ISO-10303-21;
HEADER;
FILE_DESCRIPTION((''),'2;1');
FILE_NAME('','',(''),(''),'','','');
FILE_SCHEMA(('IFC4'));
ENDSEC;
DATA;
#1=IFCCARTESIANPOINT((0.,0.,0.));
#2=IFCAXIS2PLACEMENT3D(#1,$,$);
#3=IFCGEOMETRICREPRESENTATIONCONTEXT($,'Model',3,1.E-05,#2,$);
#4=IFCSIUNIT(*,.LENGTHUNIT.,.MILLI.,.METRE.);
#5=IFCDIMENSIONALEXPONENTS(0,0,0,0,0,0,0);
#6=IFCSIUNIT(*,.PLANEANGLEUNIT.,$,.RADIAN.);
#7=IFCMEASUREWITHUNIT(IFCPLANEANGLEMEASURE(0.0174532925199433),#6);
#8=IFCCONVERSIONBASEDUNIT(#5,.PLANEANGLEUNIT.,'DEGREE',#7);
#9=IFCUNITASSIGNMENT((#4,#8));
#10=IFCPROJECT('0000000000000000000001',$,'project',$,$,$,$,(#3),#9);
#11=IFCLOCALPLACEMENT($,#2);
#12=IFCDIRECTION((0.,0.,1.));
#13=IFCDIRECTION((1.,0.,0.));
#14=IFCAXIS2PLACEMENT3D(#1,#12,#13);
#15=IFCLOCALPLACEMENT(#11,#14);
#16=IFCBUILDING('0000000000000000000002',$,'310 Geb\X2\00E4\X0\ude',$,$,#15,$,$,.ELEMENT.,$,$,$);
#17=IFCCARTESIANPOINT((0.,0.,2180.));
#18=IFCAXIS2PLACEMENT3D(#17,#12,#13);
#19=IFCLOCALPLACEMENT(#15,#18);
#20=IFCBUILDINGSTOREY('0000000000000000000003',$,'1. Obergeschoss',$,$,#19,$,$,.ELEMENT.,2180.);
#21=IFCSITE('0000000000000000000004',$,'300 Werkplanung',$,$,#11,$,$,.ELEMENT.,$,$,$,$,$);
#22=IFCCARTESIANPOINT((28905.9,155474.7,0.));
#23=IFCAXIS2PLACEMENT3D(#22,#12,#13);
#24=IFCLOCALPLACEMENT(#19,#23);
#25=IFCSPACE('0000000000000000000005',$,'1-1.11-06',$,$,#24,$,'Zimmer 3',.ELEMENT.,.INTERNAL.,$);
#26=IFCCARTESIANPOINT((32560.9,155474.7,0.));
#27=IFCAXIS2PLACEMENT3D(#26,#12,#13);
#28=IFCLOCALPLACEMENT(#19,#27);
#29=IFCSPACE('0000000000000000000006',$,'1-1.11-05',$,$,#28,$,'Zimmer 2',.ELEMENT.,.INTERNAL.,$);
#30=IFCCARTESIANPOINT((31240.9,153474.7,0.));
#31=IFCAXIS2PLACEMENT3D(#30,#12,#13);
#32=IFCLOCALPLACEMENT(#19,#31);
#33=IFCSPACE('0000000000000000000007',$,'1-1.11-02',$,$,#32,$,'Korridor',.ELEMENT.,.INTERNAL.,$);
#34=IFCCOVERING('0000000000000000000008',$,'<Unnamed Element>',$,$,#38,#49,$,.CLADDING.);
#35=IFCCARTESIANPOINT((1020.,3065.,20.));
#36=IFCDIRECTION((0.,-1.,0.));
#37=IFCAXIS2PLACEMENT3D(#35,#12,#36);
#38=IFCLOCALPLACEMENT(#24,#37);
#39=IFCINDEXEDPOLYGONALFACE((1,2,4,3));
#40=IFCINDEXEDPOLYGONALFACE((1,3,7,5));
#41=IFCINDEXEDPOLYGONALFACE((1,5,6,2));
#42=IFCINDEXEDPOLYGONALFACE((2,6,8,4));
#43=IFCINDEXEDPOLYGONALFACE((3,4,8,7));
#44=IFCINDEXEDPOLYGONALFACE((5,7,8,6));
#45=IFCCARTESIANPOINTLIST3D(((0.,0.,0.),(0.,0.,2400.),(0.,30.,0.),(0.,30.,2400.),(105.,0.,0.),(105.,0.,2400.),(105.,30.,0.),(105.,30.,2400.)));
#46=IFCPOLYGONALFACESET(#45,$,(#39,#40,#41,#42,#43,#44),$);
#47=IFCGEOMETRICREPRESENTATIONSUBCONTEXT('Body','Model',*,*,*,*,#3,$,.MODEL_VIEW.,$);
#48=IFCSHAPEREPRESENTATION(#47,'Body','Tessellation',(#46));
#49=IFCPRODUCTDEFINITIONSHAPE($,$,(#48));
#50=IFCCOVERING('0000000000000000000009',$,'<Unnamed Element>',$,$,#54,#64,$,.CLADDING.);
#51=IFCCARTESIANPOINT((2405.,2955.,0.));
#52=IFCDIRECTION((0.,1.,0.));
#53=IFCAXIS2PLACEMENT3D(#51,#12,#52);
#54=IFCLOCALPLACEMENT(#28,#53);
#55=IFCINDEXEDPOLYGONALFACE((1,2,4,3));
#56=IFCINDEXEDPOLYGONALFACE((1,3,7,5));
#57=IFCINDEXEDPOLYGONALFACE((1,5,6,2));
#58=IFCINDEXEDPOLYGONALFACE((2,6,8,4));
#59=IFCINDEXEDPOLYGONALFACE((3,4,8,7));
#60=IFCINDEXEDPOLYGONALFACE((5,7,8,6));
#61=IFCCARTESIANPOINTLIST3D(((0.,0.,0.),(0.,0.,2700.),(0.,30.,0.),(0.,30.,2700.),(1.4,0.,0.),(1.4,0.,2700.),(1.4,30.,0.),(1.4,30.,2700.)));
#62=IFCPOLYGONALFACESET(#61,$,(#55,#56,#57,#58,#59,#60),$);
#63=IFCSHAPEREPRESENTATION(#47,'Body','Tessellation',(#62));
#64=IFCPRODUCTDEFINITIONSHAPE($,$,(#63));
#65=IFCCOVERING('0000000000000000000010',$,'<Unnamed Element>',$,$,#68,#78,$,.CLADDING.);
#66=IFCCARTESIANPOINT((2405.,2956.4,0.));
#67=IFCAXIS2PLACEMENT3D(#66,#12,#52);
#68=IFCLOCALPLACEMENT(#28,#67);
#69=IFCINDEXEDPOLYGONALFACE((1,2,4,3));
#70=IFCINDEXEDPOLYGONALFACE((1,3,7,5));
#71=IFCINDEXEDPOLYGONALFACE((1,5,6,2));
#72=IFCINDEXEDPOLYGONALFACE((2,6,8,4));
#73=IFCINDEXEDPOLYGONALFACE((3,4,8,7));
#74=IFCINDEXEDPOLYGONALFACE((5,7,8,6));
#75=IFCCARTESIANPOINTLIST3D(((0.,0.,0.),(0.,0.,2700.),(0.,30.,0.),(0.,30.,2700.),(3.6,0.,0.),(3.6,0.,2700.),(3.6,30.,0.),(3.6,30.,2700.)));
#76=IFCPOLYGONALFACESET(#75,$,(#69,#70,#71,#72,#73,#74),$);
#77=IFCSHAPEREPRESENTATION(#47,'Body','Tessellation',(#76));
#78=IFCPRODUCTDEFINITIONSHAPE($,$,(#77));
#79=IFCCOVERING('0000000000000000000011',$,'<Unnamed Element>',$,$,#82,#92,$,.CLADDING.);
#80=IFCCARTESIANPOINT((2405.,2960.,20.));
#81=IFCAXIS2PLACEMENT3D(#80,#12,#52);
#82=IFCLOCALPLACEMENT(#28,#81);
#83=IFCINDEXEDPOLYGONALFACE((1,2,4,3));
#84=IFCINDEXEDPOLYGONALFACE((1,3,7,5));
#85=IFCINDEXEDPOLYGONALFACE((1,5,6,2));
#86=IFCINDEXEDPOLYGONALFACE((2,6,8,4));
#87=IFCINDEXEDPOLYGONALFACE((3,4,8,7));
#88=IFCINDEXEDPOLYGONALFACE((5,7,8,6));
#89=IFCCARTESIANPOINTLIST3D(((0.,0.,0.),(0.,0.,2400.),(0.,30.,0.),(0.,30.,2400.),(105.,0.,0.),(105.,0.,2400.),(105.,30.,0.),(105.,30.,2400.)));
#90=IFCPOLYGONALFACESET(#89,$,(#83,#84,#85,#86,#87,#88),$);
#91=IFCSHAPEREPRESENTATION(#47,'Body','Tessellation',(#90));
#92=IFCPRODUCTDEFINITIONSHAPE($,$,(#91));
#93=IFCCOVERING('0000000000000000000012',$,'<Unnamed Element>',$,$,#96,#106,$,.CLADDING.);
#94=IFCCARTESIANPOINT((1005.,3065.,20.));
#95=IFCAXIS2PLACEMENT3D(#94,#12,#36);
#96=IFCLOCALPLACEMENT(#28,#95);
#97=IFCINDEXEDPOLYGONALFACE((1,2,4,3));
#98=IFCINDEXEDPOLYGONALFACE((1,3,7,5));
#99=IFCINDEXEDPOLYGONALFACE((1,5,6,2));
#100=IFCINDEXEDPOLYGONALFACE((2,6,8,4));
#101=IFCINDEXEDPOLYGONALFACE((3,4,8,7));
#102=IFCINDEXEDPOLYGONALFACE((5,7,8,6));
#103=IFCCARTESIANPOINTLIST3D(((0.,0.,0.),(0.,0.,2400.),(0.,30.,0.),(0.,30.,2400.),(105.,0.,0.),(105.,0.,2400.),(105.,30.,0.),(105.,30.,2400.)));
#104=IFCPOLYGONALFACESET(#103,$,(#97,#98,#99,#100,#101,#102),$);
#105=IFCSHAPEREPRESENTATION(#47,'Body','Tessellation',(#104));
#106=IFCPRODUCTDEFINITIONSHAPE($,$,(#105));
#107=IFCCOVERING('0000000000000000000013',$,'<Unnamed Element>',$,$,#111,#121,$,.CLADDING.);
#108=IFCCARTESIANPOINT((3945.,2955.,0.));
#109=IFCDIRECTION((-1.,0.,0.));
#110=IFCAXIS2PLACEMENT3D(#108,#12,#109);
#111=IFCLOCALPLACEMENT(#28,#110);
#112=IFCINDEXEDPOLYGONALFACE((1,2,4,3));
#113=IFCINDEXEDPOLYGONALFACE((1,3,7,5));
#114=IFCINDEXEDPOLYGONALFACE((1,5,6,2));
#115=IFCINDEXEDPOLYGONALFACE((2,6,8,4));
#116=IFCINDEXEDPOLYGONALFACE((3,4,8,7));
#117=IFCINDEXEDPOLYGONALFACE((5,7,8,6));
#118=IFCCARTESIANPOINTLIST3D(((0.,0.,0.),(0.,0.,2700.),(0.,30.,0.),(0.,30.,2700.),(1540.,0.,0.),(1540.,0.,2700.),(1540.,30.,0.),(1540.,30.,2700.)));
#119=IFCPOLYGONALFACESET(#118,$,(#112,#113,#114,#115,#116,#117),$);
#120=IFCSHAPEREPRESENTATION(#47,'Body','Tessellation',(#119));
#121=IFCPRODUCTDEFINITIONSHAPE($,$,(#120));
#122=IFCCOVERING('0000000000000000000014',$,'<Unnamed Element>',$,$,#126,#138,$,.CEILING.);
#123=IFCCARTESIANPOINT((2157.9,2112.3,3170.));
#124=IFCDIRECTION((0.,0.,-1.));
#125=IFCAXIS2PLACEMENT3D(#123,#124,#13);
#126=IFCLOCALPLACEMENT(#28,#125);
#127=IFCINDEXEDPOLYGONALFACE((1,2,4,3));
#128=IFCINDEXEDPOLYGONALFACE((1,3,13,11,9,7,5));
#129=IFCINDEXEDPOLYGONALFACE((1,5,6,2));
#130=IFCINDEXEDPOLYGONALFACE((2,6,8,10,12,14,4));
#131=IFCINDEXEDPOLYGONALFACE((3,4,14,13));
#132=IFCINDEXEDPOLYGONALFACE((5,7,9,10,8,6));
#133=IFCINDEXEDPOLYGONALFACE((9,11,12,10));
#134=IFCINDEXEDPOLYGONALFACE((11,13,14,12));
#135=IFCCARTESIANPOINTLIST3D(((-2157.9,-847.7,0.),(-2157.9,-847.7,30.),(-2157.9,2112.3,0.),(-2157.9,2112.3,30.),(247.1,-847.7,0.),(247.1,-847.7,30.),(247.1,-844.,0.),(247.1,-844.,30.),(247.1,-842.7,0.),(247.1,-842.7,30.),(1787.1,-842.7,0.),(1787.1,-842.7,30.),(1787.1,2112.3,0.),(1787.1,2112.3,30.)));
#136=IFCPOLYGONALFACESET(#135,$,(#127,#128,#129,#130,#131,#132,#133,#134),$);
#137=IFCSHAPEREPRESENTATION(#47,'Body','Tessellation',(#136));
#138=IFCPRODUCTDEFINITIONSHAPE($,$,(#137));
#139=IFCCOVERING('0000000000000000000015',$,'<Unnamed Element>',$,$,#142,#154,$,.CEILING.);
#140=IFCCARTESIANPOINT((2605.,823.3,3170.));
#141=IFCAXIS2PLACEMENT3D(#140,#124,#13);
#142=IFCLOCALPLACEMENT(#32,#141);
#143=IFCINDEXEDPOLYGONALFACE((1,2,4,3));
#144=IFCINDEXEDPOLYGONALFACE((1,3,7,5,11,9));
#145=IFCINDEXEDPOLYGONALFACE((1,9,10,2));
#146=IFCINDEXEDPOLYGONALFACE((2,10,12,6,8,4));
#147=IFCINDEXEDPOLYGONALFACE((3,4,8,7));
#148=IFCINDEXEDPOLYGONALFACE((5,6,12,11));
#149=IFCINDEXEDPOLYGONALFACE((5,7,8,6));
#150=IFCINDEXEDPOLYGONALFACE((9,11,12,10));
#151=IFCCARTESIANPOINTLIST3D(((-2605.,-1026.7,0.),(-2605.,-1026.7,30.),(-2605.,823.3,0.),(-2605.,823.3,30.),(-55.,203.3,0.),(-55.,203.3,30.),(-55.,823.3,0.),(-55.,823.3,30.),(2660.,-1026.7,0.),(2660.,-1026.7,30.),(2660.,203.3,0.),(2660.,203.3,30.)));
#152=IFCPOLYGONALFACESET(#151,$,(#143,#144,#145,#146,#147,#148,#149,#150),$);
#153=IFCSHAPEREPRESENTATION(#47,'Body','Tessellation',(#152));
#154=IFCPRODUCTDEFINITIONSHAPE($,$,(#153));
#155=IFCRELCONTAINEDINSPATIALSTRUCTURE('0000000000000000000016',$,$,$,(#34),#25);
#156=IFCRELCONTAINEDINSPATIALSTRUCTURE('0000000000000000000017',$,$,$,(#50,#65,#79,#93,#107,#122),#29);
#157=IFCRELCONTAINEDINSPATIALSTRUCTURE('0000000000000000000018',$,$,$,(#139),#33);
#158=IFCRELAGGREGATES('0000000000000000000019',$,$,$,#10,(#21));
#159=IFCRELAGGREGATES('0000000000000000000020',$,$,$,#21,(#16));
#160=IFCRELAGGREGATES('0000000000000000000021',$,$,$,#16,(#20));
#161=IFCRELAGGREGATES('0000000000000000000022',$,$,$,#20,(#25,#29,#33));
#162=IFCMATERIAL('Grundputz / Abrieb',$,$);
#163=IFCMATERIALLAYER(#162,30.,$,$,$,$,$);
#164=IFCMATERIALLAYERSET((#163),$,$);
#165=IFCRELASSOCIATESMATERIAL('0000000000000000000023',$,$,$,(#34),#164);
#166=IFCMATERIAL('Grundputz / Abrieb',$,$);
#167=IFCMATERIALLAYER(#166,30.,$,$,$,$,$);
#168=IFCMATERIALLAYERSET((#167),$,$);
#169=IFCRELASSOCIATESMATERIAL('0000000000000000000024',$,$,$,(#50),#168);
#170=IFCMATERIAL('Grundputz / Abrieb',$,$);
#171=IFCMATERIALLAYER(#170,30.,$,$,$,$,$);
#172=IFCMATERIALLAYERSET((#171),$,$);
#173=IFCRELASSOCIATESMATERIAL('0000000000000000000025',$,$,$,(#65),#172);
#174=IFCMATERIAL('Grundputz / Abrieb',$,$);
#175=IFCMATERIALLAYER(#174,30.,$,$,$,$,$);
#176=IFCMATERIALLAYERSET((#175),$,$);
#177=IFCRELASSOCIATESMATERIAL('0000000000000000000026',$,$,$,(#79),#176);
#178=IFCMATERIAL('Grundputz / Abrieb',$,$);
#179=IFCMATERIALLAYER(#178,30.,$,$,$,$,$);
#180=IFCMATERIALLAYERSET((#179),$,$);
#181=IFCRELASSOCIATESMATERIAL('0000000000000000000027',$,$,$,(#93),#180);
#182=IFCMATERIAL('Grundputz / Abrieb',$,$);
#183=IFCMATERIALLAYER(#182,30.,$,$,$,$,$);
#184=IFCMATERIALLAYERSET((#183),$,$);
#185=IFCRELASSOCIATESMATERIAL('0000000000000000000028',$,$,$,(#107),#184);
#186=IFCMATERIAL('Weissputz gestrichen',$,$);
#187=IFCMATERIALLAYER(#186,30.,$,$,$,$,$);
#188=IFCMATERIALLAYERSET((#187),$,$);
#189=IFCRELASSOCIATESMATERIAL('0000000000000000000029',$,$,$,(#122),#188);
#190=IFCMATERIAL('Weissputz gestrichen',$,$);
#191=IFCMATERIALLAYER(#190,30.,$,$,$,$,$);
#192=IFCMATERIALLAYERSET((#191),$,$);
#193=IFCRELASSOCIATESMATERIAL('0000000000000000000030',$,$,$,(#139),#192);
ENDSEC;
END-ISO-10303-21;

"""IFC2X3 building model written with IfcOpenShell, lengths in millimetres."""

from ifc_helpers import new_model, entity, si_unit, converted_unit, frame, frame_2d, origin, origin_with_axes, place, context, subcontext, project, spatial, polyline, rectangle, outline, extrude, material, layer, layer_set, layer_usage, element, save


model = new_model("IFC2X3")

# Units and contexts
model_context = context("Model", 3, precision=1e-05, world=origin())
body_context = subcontext(model_context, "Body", "Model", "MODEL_VIEW")
ifc_project = project(units=[si_unit("LENGTHUNIT", "METRE", prefix="MILLI"), converted_unit("PLANEANGLEUNIT", "DEGREE", entity("IfcPlaneAngleMeasure", 0.0174532925199433), si_unit("PLANEANGLEUNIT", "RADIAN"), dimensions=[0, 0, 0, 0, 0, 0, 0])], contexts=[model_context])

# Site, building, storey
site_placement = place(None, origin())
site = spatial("IfcSite", under=ifc_project, at=site_placement, Name="300 Werkplanung", CompositionType="ELEMENT")
building_placement = place(site_placement, origin_with_axes())
building = spatial("IfcBuilding", under=site, at=building_placement, Name="310 Gebäude", CompositionType="ELEMENT")
storey_placement = place(building_placement, frame((0.0, 0.0, 2180.0), z_axis=(0.0, 0.0, 1.0), x_axis=(1.0, 0.0, 0.0)))
storey = spatial("IfcBuildingStorey", under=building, at=storey_placement, Name="1. Obergeschoss", CompositionType="ELEMENT", Elevation=2180.0)

# Shared definitions
space_1_placement = place(storey_placement, frame((28905.9, 155474.7, 0.0), z_axis=(0.0, 0.0, 1.0), x_axis=(1.0, 0.0, 0.0)))
space_1 = spatial("IfcSpace", under=storey, at=space_1_placement, Name="1-1.11-06", LongName="Zimmer 3", CompositionType="ELEMENT", InteriorOrExteriorSpace="INTERNAL")

# Covering
ifc_material_1 = material(Name="Grundputz / Abrieb")
ifc_layer_1 = layer(ifc_material_1, 30.0)
ifc_layer_set_1 = layer_set([ifc_layer_1])
ifc_layer_usage_1 = layer_usage(ifc_layer_set_1, "AXIS3", "POSITIVE", 0.0)
covering_1_placement = place(space_1_placement, frame((1020.0, 3065.0, 20.0), z_axis=(0.0, 0.0, 1.0), x_axis=(0.0, -1.0, 0.0)))
element("IfcCovering", 1, at=covering_1_placement, inside=space_1, material=ifc_layer_usage_1, Name="<Unnamed Element>", PredefinedType="CLADDING", context=body_context, shape_type="SweptSolid", body=[
    extrude(rectangle(XDim=2400.0, YDim=105.0, at=frame_2d((-52.5, 1200.0), x_axis=(0.0, 1.0))), frame((105.0, 0.0, 2400.0), z_axis=(0.0, 1.0, 0.0), x_axis=(1.0, 0.0, 0.0)), (0.0, 0.0, 1.0), 30.0),
])

# Shared definitions
space_2_placement = place(storey_placement, frame((32560.9, 155474.7, 0.0), z_axis=(0.0, 0.0, 1.0), x_axis=(1.0, 0.0, 0.0)))
space_2 = spatial("IfcSpace", under=storey, at=space_2_placement, Name="1-1.11-05", LongName="Zimmer 2", CompositionType="ELEMENT", InteriorOrExteriorSpace="INTERNAL")

# Coverings
ifc_material_2 = material(Name="Grundputz / Abrieb")
ifc_layer_2 = layer(ifc_material_2, 30.0)
ifc_layer_set_2 = layer_set([ifc_layer_2])
ifc_layer_usage_2 = layer_usage(ifc_layer_set_2, "AXIS3", "POSITIVE", 0.0)
covering_2_placement = place(space_2_placement, frame((2405.0, 2955.0, 0.0), z_axis=(0.0, 0.0, 1.0), x_axis=(0.0, 1.0, 0.0)))
element("IfcCovering", 2, at=covering_2_placement, inside=space_2, material=ifc_layer_usage_2, Name="<Unnamed Element>", PredefinedType="CLADDING", context=body_context, shape_type="SweptSolid", body=[
    extrude(rectangle(XDim=2700.0, YDim=1.4, at=frame_2d((-0.7, 1350.0), x_axis=(0.0, 1.0))), frame((1.4, 0.0, 2700.0), z_axis=(0.0, 1.0, 0.0), x_axis=(1.0, 0.0, 0.0)), (0.0, 0.0, 1.0), 30.0),
])
ifc_material_3 = material(Name="Grundputz / Abrieb")
ifc_layer_3 = layer(ifc_material_3, 30.0)
ifc_layer_set_3 = layer_set([ifc_layer_3])
ifc_layer_usage_3 = layer_usage(ifc_layer_set_3, "AXIS3", "POSITIVE", 0.0)
covering_3_placement = place(space_2_placement, frame((2405.0, 2956.4, 0.0), z_axis=(0.0, 0.0, 1.0), x_axis=(0.0, 1.0, 0.0)))
element("IfcCovering", 3, at=covering_3_placement, inside=space_2, material=ifc_layer_usage_3, Name="<Unnamed Element>", PredefinedType="CLADDING", context=body_context, shape_type="SweptSolid", body=[
    extrude(rectangle(XDim=2700.0, YDim=3.6, at=frame_2d((-1.8, 1350.0), x_axis=(0.0, 1.0))), frame((3.6, 0.0, 2700.0), z_axis=(0.0, 1.0, 0.0), x_axis=(1.0, 0.0, 0.0)), (0.0, 0.0, 1.0), 30.0),
])
ifc_material_4 = material(Name="Grundputz / Abrieb")
ifc_layer_4 = layer(ifc_material_4, 30.0)
ifc_layer_set_4 = layer_set([ifc_layer_4])
ifc_layer_usage_4 = layer_usage(ifc_layer_set_4, "AXIS3", "POSITIVE", 0.0)
covering_4_placement = place(space_2_placement, frame((2405.0, 2960.0, 20.0), z_axis=(0.0, 0.0, 1.0), x_axis=(0.0, 1.0, 0.0)))
element("IfcCovering", 4, at=covering_4_placement, inside=space_2, material=ifc_layer_usage_4, Name="<Unnamed Element>", PredefinedType="CLADDING", context=body_context, shape_type="SweptSolid", body=[
    extrude(rectangle(XDim=2400.0, YDim=105.0, at=frame_2d((-52.5, 1200.0), x_axis=(0.0, 1.0))), frame((105.0, 0.0, 2400.0), z_axis=(0.0, 1.0, 0.0), x_axis=(1.0, 0.0, 0.0)), (0.0, 0.0, 1.0), 30.0),
])
ifc_material_5 = material(Name="Grundputz / Abrieb")
ifc_layer_5 = layer(ifc_material_5, 30.0)
ifc_layer_set_5 = layer_set([ifc_layer_5])
ifc_layer_usage_5 = layer_usage(ifc_layer_set_5, "AXIS3", "POSITIVE", 0.0)
covering_5_placement = place(space_2_placement, frame((1005.0, 3065.0, 20.0), z_axis=(0.0, 0.0, 1.0), x_axis=(0.0, -1.0, 0.0)))
element("IfcCovering", 5, at=covering_5_placement, inside=space_2, material=ifc_layer_usage_5, Name="<Unnamed Element>", PredefinedType="CLADDING", context=body_context, shape_type="SweptSolid", body=[
    extrude(rectangle(XDim=2400.0, YDim=105.0, at=frame_2d((-52.5, 1200.0), x_axis=(0.0, 1.0))), frame((105.0, 0.0, 2400.0), z_axis=(0.0, 1.0, 0.0), x_axis=(1.0, 0.0, 0.0)), (0.0, 0.0, 1.0), 30.0),
])
ifc_material_6 = material(Name="Grundputz / Abrieb")
ifc_layer_6 = layer(ifc_material_6, 30.0)
ifc_layer_set_6 = layer_set([ifc_layer_6])
ifc_layer_usage_6 = layer_usage(ifc_layer_set_6, "AXIS3", "POSITIVE", 0.0)
covering_6_placement = place(space_2_placement, frame((3945.0, 2955.0, 0.0), z_axis=(0.0, 0.0, 1.0), x_axis=(-1.0, 0.0, 0.0)))
element("IfcCovering", 6, at=covering_6_placement, inside=space_2, material=ifc_layer_usage_6, Name="<Unnamed Element>", PredefinedType="CLADDING", context=body_context, shape_type="SweptSolid", body=[
    extrude(rectangle(XDim=2700.0, YDim=1540.0, at=frame_2d((-770.0, 1350.0), x_axis=(0.0, 1.0))), frame((1540.0, 0.0, 2700.0), z_axis=(0.0, 1.0, 0.0), x_axis=(1.0, 0.0, 0.0)), (0.0, 0.0, 1.0), 30.0),
])
ifc_material_7 = material(Name="Weissputz gestrichen")
ifc_layer_7 = layer(ifc_material_7, 30.0)
ifc_layer_set_7 = layer_set([ifc_layer_7])
ifc_layer_usage_7 = layer_usage(ifc_layer_set_7, "AXIS3", "POSITIVE", 0.0)
covering_7_placement = place(space_2_placement, frame((2157.9, 2112.3, 3170.0), z_axis=(0.0, 0.0, -1.0), x_axis=(1.0, 0.0, 0.0)))
element("IfcCovering", 7, at=covering_7_placement, inside=space_2, material=ifc_layer_usage_7, Name="<Unnamed Element>", PredefinedType="CEILING", context=body_context, shape_type="SweptSolid", body=[
    extrude(outline(polyline([(-2157.9, -847.7), (247.1, -847.7), (247.1, -844.0), (247.1, -842.7), (1787.1, -842.7), (1787.1, 2112.3), (-2157.9, 2112.3), (-2157.9, -847.7)])), origin_with_axes(), (0.0, 0.0, 1.0), 30.0),
])

# Shared definitions
space_3_placement = place(storey_placement, frame((31240.9, 153474.7, 0.0), z_axis=(0.0, 0.0, 1.0), x_axis=(1.0, 0.0, 0.0)))
space_3 = spatial("IfcSpace", under=storey, at=space_3_placement, Name="1-1.11-02", LongName="Korridor", CompositionType="ELEMENT", InteriorOrExteriorSpace="INTERNAL")

# Covering
ifc_material_8 = material(Name="Weissputz gestrichen")
ifc_layer_8 = layer(ifc_material_8, 30.0)
ifc_layer_set_8 = layer_set([ifc_layer_8])
ifc_layer_usage_8 = layer_usage(ifc_layer_set_8, "AXIS3", "POSITIVE", 0.0)
covering_8_placement = place(space_3_placement, frame((2605.0, 823.3, 3170.0), z_axis=(0.0, 0.0, -1.0), x_axis=(1.0, 0.0, 0.0)))
element("IfcCovering", 8, at=covering_8_placement, inside=space_3, material=ifc_layer_usage_8, Name="<Unnamed Element>", PredefinedType="CEILING", context=body_context, shape_type="SweptSolid", body=[
    extrude(outline(polyline([(-2605.0, -1026.7), (2660.0, -1026.7), (2660.0, 203.3), (-55.0, 203.3), (-55.0, 823.3), (-2605.0, 823.3), (-2605.0, -1026.7)])), origin_with_axes(), (0.0, 0.0, 1.0), 30.0),
])

save(model, "model.ifc")
